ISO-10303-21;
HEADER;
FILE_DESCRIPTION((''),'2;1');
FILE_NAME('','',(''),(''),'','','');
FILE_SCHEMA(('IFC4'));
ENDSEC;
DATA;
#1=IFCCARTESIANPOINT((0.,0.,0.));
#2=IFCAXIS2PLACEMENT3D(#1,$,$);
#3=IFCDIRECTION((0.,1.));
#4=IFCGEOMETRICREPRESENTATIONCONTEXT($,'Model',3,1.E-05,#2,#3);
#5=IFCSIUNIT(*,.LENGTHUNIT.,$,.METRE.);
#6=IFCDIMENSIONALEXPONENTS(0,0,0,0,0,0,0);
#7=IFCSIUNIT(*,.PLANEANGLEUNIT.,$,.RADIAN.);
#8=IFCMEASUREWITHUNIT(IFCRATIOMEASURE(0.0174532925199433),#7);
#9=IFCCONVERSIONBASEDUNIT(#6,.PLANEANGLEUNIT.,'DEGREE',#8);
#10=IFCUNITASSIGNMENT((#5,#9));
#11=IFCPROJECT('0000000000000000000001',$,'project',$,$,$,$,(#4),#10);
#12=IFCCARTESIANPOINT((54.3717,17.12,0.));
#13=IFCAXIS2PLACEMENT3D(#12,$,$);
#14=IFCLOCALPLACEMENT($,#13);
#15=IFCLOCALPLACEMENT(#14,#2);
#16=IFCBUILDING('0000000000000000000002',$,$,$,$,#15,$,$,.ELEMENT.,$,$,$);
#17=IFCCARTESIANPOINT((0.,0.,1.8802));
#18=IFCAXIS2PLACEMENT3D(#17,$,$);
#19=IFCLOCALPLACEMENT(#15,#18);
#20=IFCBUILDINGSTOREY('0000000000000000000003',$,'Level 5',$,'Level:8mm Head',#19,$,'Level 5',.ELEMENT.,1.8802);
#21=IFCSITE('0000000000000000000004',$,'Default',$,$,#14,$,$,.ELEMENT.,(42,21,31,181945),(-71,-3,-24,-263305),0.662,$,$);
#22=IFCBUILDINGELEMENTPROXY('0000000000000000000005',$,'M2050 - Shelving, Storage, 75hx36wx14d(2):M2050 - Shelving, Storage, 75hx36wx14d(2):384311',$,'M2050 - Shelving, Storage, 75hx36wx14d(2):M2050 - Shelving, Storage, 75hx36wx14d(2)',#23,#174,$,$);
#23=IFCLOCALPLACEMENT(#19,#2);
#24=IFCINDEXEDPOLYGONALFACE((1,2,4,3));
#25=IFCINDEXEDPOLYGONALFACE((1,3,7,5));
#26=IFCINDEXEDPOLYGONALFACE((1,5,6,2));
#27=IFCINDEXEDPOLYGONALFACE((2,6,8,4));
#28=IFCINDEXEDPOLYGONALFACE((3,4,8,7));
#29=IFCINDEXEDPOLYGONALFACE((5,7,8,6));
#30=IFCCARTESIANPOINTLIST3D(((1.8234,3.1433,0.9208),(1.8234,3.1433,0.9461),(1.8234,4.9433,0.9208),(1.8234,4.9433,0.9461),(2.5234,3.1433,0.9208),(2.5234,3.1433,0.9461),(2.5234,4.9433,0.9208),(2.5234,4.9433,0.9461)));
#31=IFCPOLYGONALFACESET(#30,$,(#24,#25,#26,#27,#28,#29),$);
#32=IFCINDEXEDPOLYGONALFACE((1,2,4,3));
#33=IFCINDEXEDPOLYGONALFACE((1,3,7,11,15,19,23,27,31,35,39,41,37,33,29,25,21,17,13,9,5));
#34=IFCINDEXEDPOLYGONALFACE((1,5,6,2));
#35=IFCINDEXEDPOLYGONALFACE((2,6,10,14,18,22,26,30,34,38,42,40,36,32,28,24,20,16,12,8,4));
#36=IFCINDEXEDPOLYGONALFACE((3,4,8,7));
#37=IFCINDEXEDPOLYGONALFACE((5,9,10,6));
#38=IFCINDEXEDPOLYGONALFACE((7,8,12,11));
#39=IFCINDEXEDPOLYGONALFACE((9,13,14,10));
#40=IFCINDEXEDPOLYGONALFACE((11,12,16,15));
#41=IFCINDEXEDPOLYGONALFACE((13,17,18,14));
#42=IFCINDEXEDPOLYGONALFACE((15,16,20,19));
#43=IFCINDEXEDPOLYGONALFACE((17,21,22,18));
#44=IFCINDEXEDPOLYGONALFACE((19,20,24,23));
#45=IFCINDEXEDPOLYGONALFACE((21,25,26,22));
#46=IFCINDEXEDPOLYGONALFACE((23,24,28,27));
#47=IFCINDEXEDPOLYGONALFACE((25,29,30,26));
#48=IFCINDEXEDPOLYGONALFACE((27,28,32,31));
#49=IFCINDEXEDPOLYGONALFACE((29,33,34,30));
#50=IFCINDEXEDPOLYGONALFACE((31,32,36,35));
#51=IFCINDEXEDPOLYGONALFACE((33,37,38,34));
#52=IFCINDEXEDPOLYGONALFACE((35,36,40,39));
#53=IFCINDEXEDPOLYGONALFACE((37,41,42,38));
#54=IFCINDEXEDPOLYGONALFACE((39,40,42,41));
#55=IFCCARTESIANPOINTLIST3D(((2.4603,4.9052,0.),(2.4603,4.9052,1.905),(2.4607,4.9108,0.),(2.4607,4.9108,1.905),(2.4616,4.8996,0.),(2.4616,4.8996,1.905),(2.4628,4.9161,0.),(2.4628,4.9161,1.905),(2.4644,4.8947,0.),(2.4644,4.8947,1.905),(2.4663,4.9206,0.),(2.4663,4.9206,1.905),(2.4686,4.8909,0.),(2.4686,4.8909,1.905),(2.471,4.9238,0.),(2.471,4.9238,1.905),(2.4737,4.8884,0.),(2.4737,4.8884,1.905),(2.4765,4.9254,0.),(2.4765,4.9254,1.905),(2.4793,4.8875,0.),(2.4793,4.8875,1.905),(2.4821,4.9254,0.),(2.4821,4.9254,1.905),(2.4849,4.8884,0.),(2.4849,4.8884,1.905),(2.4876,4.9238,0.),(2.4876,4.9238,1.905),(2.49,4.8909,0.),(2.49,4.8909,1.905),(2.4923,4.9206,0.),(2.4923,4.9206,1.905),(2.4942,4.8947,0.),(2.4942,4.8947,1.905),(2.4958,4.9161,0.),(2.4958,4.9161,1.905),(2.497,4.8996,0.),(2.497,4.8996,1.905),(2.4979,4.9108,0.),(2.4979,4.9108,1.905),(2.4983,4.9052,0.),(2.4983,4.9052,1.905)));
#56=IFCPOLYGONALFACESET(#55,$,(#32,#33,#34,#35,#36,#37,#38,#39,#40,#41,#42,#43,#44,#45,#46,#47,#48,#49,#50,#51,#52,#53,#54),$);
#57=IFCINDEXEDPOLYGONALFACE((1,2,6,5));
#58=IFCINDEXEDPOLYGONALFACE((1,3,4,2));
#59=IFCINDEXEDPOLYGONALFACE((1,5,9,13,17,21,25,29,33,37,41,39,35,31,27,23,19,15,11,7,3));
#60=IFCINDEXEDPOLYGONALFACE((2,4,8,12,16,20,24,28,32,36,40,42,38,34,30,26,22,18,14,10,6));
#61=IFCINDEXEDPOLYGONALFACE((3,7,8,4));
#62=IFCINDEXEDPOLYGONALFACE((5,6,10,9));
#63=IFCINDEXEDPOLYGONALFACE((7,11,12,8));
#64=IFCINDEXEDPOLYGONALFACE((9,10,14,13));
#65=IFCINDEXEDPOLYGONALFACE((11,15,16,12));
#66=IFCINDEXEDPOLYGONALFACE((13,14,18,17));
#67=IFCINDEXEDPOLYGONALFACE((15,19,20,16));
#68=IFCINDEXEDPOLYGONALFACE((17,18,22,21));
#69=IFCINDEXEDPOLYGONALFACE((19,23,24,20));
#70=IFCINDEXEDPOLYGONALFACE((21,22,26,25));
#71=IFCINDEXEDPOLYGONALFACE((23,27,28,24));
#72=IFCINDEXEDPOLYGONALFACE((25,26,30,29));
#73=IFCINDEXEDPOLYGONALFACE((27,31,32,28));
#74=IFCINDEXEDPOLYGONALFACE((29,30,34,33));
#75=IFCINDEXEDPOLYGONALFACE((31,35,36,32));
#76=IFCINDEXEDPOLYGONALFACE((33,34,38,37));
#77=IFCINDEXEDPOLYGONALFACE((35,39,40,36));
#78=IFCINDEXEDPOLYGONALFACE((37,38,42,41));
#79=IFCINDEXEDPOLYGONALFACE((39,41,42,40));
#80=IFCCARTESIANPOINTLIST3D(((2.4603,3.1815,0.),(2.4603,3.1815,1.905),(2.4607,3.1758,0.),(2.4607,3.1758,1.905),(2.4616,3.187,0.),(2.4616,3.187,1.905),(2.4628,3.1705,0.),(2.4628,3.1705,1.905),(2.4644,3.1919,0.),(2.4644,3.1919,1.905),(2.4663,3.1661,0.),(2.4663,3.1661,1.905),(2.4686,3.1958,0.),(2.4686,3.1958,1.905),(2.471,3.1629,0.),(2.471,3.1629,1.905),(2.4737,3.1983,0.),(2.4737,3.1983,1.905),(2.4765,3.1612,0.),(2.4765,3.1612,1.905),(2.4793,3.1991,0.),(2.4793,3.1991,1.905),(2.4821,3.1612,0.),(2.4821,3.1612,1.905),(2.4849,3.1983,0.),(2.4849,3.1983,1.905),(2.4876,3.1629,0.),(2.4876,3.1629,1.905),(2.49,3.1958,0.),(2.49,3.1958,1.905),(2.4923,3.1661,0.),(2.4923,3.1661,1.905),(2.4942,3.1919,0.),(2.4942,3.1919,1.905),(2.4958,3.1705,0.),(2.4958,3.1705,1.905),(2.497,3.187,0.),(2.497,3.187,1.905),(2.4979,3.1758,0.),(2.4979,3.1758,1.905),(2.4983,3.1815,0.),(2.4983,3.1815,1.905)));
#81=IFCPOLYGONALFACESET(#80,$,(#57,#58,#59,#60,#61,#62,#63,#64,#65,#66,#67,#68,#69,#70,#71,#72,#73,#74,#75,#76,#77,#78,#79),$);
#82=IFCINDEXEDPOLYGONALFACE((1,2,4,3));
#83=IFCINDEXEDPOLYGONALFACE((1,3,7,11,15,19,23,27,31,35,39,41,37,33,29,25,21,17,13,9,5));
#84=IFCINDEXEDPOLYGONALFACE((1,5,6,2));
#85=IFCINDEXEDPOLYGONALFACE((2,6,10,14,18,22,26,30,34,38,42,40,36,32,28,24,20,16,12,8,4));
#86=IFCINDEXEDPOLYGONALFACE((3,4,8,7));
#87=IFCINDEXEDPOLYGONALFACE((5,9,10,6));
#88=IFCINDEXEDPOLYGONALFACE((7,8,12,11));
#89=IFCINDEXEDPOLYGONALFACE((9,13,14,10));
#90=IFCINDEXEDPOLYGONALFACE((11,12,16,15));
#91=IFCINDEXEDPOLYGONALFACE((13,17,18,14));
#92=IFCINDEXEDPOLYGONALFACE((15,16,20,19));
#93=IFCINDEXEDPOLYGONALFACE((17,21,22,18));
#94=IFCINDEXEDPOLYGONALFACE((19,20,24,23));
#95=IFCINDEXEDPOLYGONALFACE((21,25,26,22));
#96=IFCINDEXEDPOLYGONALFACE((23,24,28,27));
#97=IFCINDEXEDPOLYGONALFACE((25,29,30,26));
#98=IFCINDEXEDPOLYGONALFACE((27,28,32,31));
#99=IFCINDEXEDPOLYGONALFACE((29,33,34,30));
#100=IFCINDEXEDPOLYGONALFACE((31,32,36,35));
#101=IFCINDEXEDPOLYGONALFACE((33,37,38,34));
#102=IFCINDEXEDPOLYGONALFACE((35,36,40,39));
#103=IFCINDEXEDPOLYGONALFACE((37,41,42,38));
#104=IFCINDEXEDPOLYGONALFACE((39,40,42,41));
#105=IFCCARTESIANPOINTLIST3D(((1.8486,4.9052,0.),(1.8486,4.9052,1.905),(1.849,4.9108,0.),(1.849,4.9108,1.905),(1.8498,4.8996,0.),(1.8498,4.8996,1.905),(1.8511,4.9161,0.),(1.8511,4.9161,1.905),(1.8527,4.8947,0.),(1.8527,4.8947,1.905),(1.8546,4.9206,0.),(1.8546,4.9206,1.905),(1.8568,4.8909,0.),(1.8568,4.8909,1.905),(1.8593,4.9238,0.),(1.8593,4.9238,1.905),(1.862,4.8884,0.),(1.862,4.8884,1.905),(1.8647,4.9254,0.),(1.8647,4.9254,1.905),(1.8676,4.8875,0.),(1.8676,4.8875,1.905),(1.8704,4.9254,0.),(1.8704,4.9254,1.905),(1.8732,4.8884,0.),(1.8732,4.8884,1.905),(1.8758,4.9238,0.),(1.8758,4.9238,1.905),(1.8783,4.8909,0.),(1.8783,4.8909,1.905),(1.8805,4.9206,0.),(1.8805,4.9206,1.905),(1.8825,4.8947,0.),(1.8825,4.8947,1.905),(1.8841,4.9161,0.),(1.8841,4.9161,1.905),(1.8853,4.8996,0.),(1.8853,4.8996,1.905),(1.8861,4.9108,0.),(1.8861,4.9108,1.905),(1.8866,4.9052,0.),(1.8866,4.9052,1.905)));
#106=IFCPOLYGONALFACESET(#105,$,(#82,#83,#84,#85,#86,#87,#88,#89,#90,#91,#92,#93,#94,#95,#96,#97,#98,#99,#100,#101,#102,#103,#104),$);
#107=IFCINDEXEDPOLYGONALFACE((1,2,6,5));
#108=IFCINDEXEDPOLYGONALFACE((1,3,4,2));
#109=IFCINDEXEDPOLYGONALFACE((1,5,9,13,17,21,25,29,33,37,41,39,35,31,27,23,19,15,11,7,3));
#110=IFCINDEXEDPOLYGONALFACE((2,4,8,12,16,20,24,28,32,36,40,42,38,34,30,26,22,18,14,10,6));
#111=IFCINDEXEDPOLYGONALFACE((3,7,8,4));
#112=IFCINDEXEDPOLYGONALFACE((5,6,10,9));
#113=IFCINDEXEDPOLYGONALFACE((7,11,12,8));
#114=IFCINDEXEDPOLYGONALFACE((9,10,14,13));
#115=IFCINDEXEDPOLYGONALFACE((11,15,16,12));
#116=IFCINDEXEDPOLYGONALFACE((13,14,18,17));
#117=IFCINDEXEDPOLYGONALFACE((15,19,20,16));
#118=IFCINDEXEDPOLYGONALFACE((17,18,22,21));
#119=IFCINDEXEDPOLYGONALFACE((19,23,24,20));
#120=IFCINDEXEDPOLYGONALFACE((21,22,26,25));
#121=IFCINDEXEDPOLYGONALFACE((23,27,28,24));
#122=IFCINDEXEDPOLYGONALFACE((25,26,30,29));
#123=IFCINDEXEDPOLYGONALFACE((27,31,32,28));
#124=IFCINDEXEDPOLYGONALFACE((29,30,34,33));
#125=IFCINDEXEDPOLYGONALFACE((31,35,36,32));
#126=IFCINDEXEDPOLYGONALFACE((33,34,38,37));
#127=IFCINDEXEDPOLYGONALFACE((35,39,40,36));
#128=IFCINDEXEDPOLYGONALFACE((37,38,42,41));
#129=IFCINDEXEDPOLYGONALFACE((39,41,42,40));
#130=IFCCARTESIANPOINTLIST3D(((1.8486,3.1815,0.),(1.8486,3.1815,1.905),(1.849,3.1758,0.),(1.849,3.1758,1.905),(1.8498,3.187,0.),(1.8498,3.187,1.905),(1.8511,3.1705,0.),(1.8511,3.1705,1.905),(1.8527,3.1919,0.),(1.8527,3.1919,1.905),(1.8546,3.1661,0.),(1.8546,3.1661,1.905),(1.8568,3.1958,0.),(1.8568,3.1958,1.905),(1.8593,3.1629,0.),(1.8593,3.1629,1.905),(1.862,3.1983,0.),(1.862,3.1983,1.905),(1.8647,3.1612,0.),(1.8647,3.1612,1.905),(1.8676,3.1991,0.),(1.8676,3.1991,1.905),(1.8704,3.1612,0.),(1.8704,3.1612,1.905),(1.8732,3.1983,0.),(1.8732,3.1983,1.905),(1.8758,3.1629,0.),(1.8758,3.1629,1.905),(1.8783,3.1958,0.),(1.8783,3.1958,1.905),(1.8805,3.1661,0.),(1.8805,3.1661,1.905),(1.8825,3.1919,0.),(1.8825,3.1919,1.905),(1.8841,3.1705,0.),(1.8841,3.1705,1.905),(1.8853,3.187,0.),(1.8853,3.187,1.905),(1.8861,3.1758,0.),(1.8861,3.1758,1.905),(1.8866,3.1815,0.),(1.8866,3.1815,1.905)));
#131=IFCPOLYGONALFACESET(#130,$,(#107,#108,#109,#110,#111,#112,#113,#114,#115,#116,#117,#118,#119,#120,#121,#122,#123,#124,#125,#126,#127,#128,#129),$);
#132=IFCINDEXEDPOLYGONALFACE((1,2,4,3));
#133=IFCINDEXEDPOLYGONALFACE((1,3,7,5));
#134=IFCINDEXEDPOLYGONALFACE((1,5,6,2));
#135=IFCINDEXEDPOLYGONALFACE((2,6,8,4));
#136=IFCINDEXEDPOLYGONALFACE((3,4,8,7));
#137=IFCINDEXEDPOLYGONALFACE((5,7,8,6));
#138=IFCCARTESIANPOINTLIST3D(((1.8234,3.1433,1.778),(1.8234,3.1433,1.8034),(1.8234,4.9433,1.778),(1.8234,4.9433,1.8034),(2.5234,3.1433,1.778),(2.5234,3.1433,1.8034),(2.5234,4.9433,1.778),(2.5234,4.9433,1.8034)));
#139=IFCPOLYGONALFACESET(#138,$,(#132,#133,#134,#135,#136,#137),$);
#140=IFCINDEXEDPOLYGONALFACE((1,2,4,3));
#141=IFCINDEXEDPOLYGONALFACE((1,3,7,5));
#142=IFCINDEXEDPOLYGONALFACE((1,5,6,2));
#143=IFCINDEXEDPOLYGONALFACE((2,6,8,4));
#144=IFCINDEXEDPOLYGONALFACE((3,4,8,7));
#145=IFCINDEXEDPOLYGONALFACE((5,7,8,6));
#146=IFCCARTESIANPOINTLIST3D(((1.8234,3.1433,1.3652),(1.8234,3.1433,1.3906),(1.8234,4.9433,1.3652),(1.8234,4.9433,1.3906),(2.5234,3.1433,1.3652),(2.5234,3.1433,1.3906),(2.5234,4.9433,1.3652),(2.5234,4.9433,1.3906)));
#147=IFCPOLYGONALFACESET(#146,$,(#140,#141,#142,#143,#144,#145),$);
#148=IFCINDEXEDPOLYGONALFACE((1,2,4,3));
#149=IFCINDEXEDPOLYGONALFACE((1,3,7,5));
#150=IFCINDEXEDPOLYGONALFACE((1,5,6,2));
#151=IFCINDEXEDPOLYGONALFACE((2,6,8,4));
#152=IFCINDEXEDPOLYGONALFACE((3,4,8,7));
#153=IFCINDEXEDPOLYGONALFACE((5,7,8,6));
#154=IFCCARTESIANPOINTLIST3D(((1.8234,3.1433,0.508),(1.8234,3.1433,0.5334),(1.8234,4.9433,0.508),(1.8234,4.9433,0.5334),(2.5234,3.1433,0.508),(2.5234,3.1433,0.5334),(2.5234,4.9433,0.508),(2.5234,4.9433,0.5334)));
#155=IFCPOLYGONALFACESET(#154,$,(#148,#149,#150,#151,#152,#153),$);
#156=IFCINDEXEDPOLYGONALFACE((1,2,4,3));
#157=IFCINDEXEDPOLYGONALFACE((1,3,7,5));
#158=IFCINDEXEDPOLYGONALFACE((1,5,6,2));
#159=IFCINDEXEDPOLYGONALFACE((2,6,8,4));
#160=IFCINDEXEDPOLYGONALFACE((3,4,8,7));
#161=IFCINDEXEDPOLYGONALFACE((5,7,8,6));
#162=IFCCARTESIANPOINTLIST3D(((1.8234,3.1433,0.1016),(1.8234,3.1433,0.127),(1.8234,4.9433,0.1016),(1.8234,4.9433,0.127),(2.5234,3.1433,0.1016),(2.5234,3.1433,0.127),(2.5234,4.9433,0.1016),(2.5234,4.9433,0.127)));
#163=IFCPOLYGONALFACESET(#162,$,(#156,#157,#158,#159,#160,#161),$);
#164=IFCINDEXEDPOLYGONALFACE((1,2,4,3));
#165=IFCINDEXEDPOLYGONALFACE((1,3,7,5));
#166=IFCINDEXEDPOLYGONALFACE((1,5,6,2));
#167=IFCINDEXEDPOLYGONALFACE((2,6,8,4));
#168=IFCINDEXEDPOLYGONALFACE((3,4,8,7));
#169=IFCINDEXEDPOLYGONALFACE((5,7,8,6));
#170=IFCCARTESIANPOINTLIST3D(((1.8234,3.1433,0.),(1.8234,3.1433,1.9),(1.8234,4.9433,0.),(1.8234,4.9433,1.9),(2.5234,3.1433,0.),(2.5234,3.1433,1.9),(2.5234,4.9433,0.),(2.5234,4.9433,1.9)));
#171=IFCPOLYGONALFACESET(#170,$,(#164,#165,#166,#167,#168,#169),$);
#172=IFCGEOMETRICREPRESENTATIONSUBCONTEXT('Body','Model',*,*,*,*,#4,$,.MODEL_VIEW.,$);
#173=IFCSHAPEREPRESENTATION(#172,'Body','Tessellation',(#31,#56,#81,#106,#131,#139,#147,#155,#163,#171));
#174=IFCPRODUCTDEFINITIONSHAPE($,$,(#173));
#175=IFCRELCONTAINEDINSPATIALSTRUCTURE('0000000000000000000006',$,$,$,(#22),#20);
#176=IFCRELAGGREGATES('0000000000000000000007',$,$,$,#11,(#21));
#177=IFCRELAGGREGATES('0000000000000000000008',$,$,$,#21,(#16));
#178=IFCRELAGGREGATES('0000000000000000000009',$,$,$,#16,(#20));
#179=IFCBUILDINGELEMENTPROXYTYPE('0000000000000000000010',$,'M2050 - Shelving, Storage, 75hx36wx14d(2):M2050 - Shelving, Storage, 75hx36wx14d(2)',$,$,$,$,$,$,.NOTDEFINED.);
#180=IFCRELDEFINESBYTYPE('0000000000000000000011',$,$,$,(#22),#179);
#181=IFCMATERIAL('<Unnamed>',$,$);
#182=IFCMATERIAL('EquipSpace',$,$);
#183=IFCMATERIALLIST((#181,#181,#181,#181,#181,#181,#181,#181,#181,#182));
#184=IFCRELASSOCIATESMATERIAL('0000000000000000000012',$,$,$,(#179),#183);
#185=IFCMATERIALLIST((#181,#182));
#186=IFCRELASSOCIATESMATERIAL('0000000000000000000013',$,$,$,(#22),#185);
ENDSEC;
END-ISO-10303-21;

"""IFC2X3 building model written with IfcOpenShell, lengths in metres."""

from ifc_helpers import new_model, entity, si_unit, converted_unit, direction, frame, frame_2d, origin, origin_2d_with_axis, place, context, subcontext, project, spatial, rectangle, circle, extrude, source, transform, mapped, material, material_list, type_object, type_shapes, element, save


model = new_model("IFC2X3")

# Units and contexts
model_context = context("Model", 3, precision=1e-05, world=origin(), true_north=direction((0.0, 1.0)))
body_context = subcontext(model_context, "Body", "Model", "MODEL_VIEW")
ifc_project = project(units=[si_unit("LENGTHUNIT", "METRE"), converted_unit("PLANEANGLEUNIT", "DEGREE", entity("IfcRatioMeasure", 0.0174532925199433), si_unit("PLANEANGLEUNIT", "RADIAN"), dimensions=[0, 0, 0, 0, 0, 0, 0])], contexts=[model_context])

# Site, building, storey
site_placement = place(None, frame((54.3717, 17.12, 0.0)))
site = spatial("IfcSite", under=ifc_project, at=site_placement, Name="Default", CompositionType="ELEMENT", RefLatitude=(42, 21, 31, 181945), RefLongitude=(-71, -3, -24, -263305), RefElevation=0.662)
building_placement = place(site_placement, origin())
building = spatial("IfcBuilding", under=site, at=building_placement, CompositionType="ELEMENT")
storey_placement = place(building_placement, frame((0.0, 0.0, 1.8802)))
storey = spatial("IfcBuildingStorey", under=building, at=storey_placement, Name="Level 5", ObjectType="Level:8mm Head", LongName="Level 5", CompositionType="ELEMENT", Elevation=1.8802)

# Building element proxy
ifc_material_1 = material(Name="<Unnamed>")
ifc_material_2 = material(Name="EquipSpace")
ifc_material_list_1 = material_list([ifc_material_1, ifc_material_1, ifc_material_1, ifc_material_1, ifc_material_1, ifc_material_1, ifc_material_1, ifc_material_1, ifc_material_1, ifc_material_2])
building_element_proxy_type = type_object("IfcBuildingElementProxyType", Name="M2050 - Shelving, Storage, 75hx36wx14d(2):M2050 - Shelving, Storage, 75hx36wx14d(2)", PredefinedType="NOTDEFINED", material=ifc_material_list_1)
shared_shape = source(origin(), body_context, "Body", "SweptSolid", [
    extrude(rectangle(XDim=1.8, YDim=0.7, at=origin_2d_with_axis()), frame((0.0, 0.0, 0.9207), z_axis=(0.0, 0.0, 1.0), x_axis=(-1.0, 0.0, 0.0)), (0.0, 0.0, 1.0), 0.0254),
    extrude(circle(Radius=0.0191, at=origin_2d_with_axis()), frame((0.8633, -0.3059, 0.0), z_axis=(0.0, 0.0, 1.0), x_axis=(-1.0, 0.0, 0.0)), (0.0, 0.0, 1.0), 1.905),
    extrude(circle(Radius=0.0191, at=origin_2d_with_axis()), frame((-0.8633, -0.3059, 0.0)), (0.0, 0.0, 1.0), 1.905),
    extrude(circle(Radius=0.0191, at=origin_2d_with_axis()), frame((0.8633, 0.3059, 0.0), z_axis=(0.0, 0.0, 1.0), x_axis=(-1.0, 0.0, 0.0)), (0.0, 0.0, 1.0), 1.905),
    extrude(circle(Radius=0.0191, at=origin_2d_with_axis()), frame((-0.8633, 0.3059, 0.0)), (0.0, 0.0, 1.0), 1.905),
    extrude(rectangle(XDim=1.8, YDim=0.7, at=origin_2d_with_axis()), frame((0.0, 0.0, 1.778), z_axis=(0.0, 0.0, 1.0), x_axis=(-1.0, 0.0, 0.0)), (0.0, 0.0, 1.0), 0.0254),
    extrude(rectangle(XDim=1.8, YDim=0.7, at=origin_2d_with_axis()), frame((0.0, 0.0, 1.3653), z_axis=(0.0, 0.0, 1.0), x_axis=(-1.0, 0.0, 0.0)), (0.0, 0.0, 1.0), 0.0254),
    extrude(rectangle(XDim=1.8, YDim=0.7, at=origin_2d_with_axis()), frame((0.0, 0.0, 0.508), z_axis=(0.0, 0.0, 1.0), x_axis=(-1.0, 0.0, 0.0)), (0.0, 0.0, 1.0), 0.0254),
    extrude(rectangle(XDim=1.8, YDim=0.7, at=origin_2d_with_axis()), frame((0.0, 0.0, 0.1016), z_axis=(0.0, 0.0, 1.0), x_axis=(-1.0, 0.0, 0.0)), (0.0, 0.0, 1.0), 0.0254),
    extrude(rectangle(XDim=0.7, YDim=1.8, at=frame_2d((0.0, 0.18), x_axis=(1.0, 0.0))), frame((-0.18, 0.0, 0.0), z_axis=(0.0, 0.0, 1.0), x_axis=(0.0, -1.0, 0.0)), (0.0, 0.0, 1.0), 1.9),
])
type_shapes(building_element_proxy_type, [shared_shape])
ifc_material_list_2 = material_list([ifc_material_1, ifc_material_2])
proxy_1_placement = place(storey_placement, frame((2.1734, 4.0433, 0.0), z_axis=(0.0, 0.0, 1.0), x_axis=(0.0, 1.0, 0.0)))
element("IfcBuildingElementProxy", 1, at=proxy_1_placement, inside=storey, type_object=building_element_proxy_type, material=ifc_material_list_2, Name="M2050 - Shelving, Storage, 75hx36wx14d(2):M2050 - Shelving, Storage, 75hx36wx14d(2):384311", ObjectType="M2050 - Shelving, Storage, 75hx36wx14d(2):M2050 - Shelving, Storage, 75hx36wx14d(2)", context=body_context, shape_type="MappedRepresentation", body=[
    mapped(shared_shape, transform((0.0, 0.0, 0.0), scale=1.0)),
])

save(model, "model.ifc")
